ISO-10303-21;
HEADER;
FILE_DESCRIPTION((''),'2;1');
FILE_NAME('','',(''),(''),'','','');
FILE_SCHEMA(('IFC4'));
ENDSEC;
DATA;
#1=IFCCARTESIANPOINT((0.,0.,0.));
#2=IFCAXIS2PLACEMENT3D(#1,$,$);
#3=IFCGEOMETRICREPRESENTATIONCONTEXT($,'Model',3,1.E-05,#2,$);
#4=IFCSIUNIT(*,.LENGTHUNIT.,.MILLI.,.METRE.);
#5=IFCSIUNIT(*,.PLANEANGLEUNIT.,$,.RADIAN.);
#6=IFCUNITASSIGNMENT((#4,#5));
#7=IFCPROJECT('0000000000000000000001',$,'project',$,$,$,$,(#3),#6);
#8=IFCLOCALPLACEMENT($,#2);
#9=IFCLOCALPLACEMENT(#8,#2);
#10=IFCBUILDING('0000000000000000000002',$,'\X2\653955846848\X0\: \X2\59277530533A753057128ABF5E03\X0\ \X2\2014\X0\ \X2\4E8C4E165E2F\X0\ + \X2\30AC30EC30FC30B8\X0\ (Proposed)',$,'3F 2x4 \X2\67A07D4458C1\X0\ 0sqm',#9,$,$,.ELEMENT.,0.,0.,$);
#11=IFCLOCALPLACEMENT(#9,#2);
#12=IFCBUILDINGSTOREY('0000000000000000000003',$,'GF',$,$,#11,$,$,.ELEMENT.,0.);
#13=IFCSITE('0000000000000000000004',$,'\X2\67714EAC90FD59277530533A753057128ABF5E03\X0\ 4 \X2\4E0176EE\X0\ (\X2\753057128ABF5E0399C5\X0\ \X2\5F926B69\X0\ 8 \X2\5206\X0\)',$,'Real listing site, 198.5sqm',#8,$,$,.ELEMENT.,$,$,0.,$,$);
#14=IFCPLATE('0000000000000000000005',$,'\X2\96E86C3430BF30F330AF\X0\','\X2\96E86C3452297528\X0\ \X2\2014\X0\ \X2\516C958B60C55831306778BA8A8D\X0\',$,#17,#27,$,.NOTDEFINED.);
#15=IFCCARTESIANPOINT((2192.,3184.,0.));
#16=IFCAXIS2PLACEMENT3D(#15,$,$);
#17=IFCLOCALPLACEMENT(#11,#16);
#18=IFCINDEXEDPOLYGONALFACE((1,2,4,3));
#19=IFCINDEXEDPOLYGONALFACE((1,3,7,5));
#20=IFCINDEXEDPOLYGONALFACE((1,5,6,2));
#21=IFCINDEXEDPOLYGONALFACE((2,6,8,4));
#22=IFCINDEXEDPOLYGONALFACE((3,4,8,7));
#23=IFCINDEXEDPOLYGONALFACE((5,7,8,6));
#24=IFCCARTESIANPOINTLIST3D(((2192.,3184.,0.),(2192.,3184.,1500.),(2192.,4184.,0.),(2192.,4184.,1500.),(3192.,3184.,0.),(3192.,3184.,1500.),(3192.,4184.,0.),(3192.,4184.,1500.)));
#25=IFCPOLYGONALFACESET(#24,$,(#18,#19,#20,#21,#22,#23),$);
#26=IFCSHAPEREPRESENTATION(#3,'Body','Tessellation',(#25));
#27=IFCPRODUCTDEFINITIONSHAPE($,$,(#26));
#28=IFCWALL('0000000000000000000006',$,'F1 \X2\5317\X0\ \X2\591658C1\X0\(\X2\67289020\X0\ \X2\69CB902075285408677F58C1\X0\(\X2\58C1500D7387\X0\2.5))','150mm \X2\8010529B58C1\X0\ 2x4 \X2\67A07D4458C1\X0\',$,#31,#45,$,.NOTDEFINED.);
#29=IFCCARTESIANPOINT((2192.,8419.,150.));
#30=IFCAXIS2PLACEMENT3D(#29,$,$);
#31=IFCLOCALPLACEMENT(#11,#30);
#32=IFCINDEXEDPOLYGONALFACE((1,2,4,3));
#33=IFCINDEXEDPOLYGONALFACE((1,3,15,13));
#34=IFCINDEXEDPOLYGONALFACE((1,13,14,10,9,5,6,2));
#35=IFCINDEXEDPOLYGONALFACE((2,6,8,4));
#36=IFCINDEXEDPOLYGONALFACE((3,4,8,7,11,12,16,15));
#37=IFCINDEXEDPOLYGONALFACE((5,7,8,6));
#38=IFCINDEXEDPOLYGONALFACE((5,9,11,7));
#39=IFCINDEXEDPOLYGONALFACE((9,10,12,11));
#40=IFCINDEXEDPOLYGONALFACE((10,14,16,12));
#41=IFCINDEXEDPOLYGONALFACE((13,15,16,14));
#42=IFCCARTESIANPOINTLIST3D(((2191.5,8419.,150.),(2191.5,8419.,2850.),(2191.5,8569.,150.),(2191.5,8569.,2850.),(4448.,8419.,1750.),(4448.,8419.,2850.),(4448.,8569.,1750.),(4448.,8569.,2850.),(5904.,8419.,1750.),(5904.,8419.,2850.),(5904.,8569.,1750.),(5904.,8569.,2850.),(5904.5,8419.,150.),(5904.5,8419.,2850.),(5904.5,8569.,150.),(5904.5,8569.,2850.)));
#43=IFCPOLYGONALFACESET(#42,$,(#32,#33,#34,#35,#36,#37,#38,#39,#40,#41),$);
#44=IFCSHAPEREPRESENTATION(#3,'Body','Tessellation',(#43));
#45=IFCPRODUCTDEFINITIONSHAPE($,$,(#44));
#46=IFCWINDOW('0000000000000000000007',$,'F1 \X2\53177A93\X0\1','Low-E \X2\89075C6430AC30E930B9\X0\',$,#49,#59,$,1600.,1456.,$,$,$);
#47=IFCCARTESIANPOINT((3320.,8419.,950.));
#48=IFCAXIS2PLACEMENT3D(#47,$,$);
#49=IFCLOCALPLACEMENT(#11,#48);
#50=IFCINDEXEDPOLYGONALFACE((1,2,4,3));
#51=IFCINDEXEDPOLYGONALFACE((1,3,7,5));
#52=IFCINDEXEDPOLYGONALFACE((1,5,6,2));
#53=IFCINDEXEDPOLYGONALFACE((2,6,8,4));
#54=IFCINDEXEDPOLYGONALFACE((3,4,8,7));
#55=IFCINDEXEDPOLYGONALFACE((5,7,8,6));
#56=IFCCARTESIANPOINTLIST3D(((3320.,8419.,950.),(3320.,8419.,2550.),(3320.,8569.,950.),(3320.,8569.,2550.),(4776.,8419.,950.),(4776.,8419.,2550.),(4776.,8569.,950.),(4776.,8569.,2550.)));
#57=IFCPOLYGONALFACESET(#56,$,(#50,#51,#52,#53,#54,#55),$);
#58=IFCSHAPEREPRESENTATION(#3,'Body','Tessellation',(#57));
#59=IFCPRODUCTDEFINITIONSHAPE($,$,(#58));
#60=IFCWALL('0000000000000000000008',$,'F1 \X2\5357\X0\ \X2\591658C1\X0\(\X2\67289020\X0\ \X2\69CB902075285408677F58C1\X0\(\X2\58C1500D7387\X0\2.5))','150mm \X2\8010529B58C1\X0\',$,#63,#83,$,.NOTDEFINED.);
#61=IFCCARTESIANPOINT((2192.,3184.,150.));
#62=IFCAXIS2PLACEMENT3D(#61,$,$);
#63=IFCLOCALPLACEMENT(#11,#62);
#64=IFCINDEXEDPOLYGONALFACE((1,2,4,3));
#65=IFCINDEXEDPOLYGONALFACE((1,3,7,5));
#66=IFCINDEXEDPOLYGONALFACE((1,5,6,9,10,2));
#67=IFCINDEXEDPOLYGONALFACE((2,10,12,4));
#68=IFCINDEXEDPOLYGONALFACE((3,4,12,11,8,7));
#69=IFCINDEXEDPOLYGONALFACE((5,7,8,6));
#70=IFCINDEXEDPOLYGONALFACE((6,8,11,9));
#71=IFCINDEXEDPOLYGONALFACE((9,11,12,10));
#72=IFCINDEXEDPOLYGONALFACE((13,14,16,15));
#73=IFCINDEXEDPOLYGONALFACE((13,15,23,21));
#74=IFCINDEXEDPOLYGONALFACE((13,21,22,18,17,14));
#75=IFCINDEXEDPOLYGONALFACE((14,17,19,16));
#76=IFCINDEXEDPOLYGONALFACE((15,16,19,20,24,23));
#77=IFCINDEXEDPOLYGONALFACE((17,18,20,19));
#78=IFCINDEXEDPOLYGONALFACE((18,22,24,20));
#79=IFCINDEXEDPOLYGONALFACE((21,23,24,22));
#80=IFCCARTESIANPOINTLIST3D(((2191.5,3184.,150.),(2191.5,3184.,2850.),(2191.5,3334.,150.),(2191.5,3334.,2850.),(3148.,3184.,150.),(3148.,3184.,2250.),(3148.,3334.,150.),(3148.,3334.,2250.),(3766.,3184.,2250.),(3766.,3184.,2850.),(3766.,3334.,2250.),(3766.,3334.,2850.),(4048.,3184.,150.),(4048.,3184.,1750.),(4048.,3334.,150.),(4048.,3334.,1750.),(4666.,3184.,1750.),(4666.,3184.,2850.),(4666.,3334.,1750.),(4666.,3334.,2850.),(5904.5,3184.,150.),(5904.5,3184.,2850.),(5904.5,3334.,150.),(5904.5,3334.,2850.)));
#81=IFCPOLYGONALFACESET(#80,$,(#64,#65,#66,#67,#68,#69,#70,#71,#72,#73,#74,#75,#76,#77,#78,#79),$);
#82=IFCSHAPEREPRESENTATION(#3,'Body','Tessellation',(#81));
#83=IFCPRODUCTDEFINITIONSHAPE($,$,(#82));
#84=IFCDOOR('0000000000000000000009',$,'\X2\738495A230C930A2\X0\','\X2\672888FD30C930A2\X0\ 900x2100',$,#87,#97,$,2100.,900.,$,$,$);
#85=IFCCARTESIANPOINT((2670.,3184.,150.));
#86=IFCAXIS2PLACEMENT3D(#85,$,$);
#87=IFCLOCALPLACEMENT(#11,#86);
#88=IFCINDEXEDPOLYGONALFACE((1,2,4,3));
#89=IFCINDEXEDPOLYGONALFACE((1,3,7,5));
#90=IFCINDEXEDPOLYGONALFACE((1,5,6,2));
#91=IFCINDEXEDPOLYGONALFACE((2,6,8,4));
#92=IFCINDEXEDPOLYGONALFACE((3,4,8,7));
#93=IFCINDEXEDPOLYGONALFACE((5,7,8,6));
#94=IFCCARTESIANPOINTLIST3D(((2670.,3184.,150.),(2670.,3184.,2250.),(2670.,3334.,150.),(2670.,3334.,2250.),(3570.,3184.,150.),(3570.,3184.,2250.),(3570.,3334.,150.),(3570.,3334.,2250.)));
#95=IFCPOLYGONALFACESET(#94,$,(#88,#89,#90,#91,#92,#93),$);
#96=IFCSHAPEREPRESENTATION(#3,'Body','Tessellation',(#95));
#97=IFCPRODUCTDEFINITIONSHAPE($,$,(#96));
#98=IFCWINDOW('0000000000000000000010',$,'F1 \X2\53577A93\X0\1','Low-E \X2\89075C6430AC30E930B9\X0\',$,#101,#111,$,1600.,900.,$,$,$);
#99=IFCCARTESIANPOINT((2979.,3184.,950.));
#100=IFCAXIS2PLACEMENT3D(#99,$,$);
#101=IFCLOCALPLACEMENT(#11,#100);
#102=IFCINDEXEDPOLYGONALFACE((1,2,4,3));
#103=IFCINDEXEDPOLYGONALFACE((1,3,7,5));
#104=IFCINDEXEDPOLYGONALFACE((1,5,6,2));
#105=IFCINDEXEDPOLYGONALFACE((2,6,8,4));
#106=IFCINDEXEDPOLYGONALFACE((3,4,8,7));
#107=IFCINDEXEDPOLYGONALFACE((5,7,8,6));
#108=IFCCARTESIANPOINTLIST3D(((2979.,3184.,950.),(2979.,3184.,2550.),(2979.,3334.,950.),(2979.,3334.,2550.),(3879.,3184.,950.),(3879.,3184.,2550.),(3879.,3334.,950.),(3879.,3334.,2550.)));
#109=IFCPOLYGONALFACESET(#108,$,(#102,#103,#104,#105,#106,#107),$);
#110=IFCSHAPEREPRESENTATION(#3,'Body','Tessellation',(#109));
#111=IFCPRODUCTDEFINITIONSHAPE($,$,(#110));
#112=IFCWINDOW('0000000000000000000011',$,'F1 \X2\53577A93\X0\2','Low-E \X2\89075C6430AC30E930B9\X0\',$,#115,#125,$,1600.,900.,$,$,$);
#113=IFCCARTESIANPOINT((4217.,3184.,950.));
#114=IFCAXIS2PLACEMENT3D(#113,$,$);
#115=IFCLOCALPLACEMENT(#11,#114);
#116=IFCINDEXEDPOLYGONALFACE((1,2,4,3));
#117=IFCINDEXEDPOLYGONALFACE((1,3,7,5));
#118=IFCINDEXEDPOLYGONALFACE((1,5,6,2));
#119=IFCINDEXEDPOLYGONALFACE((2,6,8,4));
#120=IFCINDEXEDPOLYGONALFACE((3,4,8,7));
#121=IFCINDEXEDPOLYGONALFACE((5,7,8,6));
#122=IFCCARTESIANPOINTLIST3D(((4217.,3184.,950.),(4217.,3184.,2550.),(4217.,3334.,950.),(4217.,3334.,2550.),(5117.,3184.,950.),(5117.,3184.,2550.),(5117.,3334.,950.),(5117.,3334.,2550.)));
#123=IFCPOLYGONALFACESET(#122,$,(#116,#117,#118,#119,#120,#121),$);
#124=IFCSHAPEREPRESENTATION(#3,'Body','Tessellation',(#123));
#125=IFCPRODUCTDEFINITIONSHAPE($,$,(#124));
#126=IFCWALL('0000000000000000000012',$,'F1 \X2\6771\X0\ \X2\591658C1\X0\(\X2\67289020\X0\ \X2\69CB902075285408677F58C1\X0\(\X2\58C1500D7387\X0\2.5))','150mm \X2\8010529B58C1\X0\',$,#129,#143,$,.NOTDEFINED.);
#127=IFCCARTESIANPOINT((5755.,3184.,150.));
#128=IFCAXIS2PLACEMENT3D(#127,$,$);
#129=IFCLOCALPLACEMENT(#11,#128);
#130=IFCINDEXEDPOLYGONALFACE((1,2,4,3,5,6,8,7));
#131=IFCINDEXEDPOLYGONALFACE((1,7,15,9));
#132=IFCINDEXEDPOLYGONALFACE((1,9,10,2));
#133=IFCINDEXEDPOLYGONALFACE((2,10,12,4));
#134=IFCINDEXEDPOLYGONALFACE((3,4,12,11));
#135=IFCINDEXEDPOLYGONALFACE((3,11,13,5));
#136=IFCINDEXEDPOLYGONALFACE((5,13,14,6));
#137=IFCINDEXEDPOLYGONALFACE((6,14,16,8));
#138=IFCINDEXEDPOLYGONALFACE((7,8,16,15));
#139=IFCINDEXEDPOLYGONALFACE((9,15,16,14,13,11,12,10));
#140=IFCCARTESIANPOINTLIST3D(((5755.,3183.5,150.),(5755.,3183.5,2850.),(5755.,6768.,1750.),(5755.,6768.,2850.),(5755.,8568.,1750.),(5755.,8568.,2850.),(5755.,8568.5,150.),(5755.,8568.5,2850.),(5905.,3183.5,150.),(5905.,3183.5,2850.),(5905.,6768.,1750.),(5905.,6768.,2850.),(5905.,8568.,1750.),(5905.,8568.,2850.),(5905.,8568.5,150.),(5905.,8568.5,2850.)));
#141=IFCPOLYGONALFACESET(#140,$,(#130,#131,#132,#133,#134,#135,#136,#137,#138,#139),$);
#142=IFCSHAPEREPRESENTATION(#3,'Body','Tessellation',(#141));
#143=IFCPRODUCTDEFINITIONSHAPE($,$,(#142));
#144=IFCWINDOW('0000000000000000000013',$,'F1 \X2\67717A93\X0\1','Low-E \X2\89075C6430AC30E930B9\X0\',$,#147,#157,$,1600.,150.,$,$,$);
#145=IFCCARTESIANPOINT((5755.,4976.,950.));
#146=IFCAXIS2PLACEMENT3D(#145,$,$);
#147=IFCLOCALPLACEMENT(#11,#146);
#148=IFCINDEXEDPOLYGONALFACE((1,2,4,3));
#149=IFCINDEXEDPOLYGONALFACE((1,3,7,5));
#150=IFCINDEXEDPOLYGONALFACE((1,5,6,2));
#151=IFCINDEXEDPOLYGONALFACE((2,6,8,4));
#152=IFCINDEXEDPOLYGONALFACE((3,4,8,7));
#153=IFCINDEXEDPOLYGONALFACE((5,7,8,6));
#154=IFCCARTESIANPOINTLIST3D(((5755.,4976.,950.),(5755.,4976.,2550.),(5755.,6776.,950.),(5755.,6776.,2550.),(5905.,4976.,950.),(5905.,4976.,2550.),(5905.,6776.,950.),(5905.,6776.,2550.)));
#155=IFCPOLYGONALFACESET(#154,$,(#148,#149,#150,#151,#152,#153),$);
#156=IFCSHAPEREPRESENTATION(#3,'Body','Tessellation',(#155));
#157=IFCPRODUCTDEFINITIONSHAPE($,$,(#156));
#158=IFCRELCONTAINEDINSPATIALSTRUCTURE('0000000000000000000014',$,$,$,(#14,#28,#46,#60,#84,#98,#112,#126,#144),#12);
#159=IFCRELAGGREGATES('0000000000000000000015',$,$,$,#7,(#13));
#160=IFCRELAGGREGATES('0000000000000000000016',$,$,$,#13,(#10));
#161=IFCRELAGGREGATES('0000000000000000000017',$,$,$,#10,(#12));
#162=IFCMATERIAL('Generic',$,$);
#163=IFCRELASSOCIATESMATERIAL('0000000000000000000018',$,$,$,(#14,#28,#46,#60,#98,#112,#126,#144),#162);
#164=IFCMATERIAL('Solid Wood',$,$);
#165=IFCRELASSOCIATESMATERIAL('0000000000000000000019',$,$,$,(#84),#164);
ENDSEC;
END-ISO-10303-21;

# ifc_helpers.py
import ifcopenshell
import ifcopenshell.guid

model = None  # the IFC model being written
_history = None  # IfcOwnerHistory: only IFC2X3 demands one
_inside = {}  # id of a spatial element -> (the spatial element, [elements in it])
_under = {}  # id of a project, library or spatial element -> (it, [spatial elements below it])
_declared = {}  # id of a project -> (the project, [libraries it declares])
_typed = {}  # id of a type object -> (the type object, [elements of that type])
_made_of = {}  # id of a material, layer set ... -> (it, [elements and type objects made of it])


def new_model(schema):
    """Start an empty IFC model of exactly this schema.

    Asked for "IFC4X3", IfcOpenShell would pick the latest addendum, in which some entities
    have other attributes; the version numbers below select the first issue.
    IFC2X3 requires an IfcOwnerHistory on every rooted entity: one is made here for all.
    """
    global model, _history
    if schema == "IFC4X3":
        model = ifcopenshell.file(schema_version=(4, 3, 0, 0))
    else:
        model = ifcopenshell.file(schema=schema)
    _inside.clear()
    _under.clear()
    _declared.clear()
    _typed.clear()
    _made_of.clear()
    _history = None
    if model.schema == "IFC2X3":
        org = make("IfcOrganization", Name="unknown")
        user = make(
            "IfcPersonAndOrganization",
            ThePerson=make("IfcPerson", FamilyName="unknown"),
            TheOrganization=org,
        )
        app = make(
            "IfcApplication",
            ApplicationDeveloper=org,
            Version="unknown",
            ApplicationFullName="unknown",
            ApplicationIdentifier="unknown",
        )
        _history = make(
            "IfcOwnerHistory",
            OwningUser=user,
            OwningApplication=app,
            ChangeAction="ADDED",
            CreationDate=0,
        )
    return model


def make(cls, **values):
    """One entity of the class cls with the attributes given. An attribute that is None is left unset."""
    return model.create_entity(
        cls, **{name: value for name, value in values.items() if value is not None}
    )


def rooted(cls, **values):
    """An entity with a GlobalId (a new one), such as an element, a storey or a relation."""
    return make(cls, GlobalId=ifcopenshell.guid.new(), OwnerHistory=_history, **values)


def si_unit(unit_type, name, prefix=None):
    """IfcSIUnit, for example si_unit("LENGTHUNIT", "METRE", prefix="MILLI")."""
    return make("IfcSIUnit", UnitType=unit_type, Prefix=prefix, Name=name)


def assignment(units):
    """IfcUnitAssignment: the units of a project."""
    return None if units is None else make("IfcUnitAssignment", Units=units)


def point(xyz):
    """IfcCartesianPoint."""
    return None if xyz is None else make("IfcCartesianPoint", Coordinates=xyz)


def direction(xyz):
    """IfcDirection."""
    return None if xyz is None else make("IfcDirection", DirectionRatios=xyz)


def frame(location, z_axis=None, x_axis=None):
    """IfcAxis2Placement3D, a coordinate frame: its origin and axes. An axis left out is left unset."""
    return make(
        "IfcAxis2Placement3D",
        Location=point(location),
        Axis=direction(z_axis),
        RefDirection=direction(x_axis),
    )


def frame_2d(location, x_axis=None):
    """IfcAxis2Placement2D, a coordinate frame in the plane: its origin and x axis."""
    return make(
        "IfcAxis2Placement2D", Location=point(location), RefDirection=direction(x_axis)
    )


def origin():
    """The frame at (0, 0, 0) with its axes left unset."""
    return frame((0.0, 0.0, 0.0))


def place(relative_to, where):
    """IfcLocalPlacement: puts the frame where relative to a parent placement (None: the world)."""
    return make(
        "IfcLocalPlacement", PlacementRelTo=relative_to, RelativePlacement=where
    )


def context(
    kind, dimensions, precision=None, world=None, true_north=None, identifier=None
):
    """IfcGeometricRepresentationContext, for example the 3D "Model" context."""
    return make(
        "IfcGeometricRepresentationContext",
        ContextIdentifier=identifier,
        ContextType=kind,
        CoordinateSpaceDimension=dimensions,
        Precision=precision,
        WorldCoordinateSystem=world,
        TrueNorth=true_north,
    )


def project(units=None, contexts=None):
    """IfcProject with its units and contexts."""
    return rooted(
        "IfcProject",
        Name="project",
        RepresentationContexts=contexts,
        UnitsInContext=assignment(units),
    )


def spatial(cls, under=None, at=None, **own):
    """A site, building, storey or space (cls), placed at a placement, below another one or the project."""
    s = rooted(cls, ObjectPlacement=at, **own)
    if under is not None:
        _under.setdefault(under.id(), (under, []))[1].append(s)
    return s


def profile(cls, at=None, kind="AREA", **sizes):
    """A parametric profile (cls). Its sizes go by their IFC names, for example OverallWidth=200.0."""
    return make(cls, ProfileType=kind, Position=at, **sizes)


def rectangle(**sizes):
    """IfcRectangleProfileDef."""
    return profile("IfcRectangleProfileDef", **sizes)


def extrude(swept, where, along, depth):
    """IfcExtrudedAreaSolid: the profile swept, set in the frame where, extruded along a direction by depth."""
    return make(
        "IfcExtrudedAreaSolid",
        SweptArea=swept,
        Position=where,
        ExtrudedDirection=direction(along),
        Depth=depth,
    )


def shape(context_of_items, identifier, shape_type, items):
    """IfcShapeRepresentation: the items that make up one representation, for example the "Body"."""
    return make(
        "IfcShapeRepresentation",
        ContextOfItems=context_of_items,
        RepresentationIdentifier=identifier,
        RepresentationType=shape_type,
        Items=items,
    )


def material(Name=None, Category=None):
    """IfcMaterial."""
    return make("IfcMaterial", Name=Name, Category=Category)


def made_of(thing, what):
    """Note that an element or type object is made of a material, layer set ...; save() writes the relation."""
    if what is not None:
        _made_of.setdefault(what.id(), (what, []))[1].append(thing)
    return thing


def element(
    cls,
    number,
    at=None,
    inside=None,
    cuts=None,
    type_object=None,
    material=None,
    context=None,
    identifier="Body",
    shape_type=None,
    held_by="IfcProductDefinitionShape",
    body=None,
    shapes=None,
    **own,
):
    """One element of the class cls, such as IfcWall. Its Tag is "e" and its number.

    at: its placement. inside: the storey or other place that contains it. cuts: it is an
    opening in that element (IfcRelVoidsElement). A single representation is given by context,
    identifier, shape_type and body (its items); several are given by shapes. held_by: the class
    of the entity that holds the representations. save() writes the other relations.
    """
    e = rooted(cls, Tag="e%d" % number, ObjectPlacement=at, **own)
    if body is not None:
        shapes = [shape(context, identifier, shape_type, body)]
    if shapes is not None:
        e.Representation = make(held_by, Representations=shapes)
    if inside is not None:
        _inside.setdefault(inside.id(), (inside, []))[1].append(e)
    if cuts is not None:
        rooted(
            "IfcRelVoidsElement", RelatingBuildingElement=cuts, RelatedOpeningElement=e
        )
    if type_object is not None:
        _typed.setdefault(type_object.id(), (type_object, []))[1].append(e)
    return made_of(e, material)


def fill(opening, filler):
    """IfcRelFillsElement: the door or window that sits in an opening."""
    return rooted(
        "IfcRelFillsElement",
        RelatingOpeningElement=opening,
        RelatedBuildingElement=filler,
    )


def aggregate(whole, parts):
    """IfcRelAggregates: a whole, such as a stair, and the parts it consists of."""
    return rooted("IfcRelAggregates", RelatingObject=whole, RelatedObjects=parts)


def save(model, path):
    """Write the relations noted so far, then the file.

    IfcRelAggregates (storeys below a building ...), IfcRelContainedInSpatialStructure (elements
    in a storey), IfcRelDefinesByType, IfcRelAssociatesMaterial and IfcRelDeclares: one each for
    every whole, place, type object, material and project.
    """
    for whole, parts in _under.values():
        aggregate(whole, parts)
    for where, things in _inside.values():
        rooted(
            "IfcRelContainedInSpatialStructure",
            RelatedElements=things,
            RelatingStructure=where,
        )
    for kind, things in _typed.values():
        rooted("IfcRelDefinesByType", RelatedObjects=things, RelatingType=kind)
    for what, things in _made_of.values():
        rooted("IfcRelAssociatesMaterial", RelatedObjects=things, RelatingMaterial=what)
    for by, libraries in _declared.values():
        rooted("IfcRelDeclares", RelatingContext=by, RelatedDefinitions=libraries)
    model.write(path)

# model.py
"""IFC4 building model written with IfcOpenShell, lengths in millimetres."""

from ifc_helpers import new_model, si_unit, frame, frame_2d, origin, place, context, project, spatial, rectangle, extrude, material, element, fill, save


model = new_model("IFC4")

# Units and contexts
model_context = context("Model", 3, precision=1e-05, world=origin())
ifc_project = project(units=[si_unit("LENGTHUNIT", "METRE", prefix="MILLI"), si_unit("PLANEANGLEUNIT", "RADIAN")], contexts=[model_context])

# Site, building, storey
site_placement = place(None, origin())
site = spatial("IfcSite", under=ifc_project, at=site_placement, Name="東京都大田区田園調布 4 丁目 (田園調布駅 徒歩 8 分)", ObjectType="Real listing site, 198.5sqm", CompositionType="ELEMENT", RefElevation=0.0)
building_placement = place(site_placement, origin())
building = spatial("IfcBuilding", under=site, at=building_placement, Name="改善案: 大田区田園調布 — 二世帯 + ガレージ (Proposed)", ObjectType="3F 2x4 枠組壁 0sqm", CompositionType="ELEMENT", ElevationOfRefHeight=0.0, ElevationOfTerrain=0.0)
storey_placement = place(building_placement, origin())
storey = spatial("IfcBuildingStorey", under=building, at=storey_placement, Name="GF", CompositionType="ELEMENT", Elevation=0.0)

# Shared definitions
ifc_material_1 = material(Name="Generic")

# Plate
plate_placement = place(storey_placement, frame((2192.0, 3184.0, 0.0)))
element("IfcPlate", 1, at=plate_placement, inside=storey, material=ifc_material_1, Name="雨水タンク", Description="雨水利用 — 公開情報で確認", PredefinedType="NOTDEFINED", context=model_context, shape_type="SweptSolid", body=[
    extrude(rectangle(XDim=1000.0, YDim=1000.0, at=frame_2d((500.0, 500.0))), frame((2192.0, 3184.0, 0.0)), (0.0, 0.0, 1.0), 1500.0),
])

# Wall, opening, window
wall_1_placement = place(storey_placement, frame((2192.0, 8419.0, 150.0)))
wall_1 = element("IfcWall", 2, at=wall_1_placement, inside=storey, material=ifc_material_1, Name="F1 北 外壁(木造 構造用合板壁(壁倍率2.5))", Description="150mm 耐力壁 2x4 枠組壁", PredefinedType="NOTDEFINED", context=model_context, shape_type="SweptSolid", body=[
    extrude(rectangle(XDim=3713.0, YDim=150.0, at=frame_2d((1856.0, 75.0))), frame((2192.0, 8419.0, 150.0)), (0.0, 0.0, 1.0), 2700.0),
])
opening_1_placement = place(storey_placement, frame((3320.0, 8419.0, 950.0)))
opening_1 = element("IfcOpeningElement", 3, at=opening_1_placement, cuts=wall_1, PredefinedType="NOTDEFINED", context=model_context, shape_type="SweptSolid", body=[
    extrude(rectangle(XDim=1456.0, YDim=150.0, at=frame_2d((728.0, 75.0))), frame((3320.0, 8419.0, 950.0)), (0.0, 0.0, 1.0), 1600.0),
])
window_1_placement = place(storey_placement, frame((3320.0, 8419.0, 950.0)))
window_1 = element("IfcWindow", 4, at=window_1_placement, inside=storey, material=ifc_material_1, Name="F1 北窓1", Description="Low-E 複層ガラス", OverallHeight=1600.0, OverallWidth=1456.0, context=model_context, shape_type="SweptSolid", body=[
    extrude(rectangle(XDim=1456.0, YDim=150.0, at=frame_2d((728.0, 75.0))), frame((3320.0, 8419.0, 950.0)), (0.0, 0.0, 1.0), 1600.0),
])
fill(opening_1, window_1)

# Wall, openings, door, windows
wall_2_placement = place(storey_placement, frame((2192.0, 3184.0, 150.0)))
wall_2 = element("IfcWall", 5, at=wall_2_placement, inside=storey, material=ifc_material_1, Name="F1 南 外壁(木造 構造用合板壁(壁倍率2.5))", Description="150mm 耐力壁", PredefinedType="NOTDEFINED", context=model_context, shape_type="SweptSolid", body=[
    extrude(rectangle(XDim=3713.0, YDim=150.0, at=frame_2d((1856.0, 75.0))), frame((2192.0, 3184.0, 150.0)), (0.0, 0.0, 1.0), 2700.0),
])
opening_2_placement = place(storey_placement, frame((2670.0, 3184.0, 150.0)))
opening_2 = element("IfcOpeningElement", 6, at=opening_2_placement, cuts=wall_2, PredefinedType="NOTDEFINED", context=model_context, shape_type="SweptSolid", body=[
    extrude(rectangle(XDim=900.0, YDim=150.0, at=frame_2d((450.0, 75.0))), frame((2670.0, 3184.0, 150.0)), (0.0, 0.0, 1.0), 2100.0),
])
opening_3_placement = place(storey_placement, frame((2979.0, 3184.0, 950.0)))
opening_3 = element("IfcOpeningElement", 7, at=opening_3_placement, cuts=wall_2, PredefinedType="NOTDEFINED", context=model_context, shape_type="SweptSolid", body=[
    extrude(rectangle(XDim=900.0, YDim=150.0, at=frame_2d((450.0, 75.0))), frame((2979.0, 3184.0, 950.0)), (0.0, 0.0, 1.0), 1600.0),
])
opening_4_placement = place(storey_placement, frame((4217.0, 3184.0, 950.0)))
opening_4 = element("IfcOpeningElement", 8, at=opening_4_placement, cuts=wall_2, PredefinedType="NOTDEFINED", context=model_context, shape_type="SweptSolid", body=[
    extrude(rectangle(XDim=900.0, YDim=150.0, at=frame_2d((450.0, 75.0))), frame((4217.0, 3184.0, 950.0)), (0.0, 0.0, 1.0), 1600.0),
])
ifc_material_2 = material(Name="Solid Wood")
door_placement = place(storey_placement, frame((2670.0, 3184.0, 150.0)))
door = element("IfcDoor", 9, at=door_placement, inside=storey, material=ifc_material_2, Name="玄関ドア", Description="木製ドア 900x2100", OverallHeight=2100.0, OverallWidth=900.0, context=model_context, shape_type="SweptSolid", body=[
    extrude(rectangle(XDim=900.0, YDim=150.0, at=frame_2d((450.0, 75.0))), frame((2670.0, 3184.0, 150.0)), (0.0, 0.0, 1.0), 2100.0),
])
fill(opening_2, door)
window_2_placement = place(storey_placement, frame((2979.0, 3184.0, 950.0)))
window_2 = element("IfcWindow", 10, at=window_2_placement, inside=storey, material=ifc_material_1, Name="F1 南窓1", Description="Low-E 複層ガラス", OverallHeight=1600.0, OverallWidth=900.0, context=model_context, shape_type="SweptSolid", body=[
    extrude(rectangle(XDim=900.0, YDim=150.0, at=frame_2d((450.0, 75.0))), frame((2979.0, 3184.0, 950.0)), (0.0, 0.0, 1.0), 1600.0),
])
fill(opening_3, window_2)
window_3_placement = place(storey_placement, frame((4217.0, 3184.0, 950.0)))
window_3 = element("IfcWindow", 11, at=window_3_placement, inside=storey, material=ifc_material_1, Name="F1 南窓2", Description="Low-E 複層ガラス", OverallHeight=1600.0, OverallWidth=900.0, context=model_context, shape_type="SweptSolid", body=[
    extrude(rectangle(XDim=900.0, YDim=150.0, at=frame_2d((450.0, 75.0))), frame((4217.0, 3184.0, 950.0)), (0.0, 0.0, 1.0), 1600.0),
])
fill(opening_4, window_3)

# Wall, opening, window
wall_3_placement = place(storey_placement, frame((5755.0, 3184.0, 150.0)))
wall_3 = element("IfcWall", 12, at=wall_3_placement, inside=storey, material=ifc_material_1, Name="F1 東 外壁(木造 構造用合板壁(壁倍率2.5))", Description="150mm 耐力壁", PredefinedType="NOTDEFINED", context=model_context, shape_type="SweptSolid", body=[
    extrude(rectangle(XDim=150.0, YDim=5385.0, at=frame_2d((75.0, 2692.0))), frame((5755.0, 3184.0, 150.0)), (0.0, 0.0, 1.0), 2700.0),
])
opening_5_placement = place(storey_placement, frame((5755.0, 4976.0, 950.0)))
opening_5 = element("IfcOpeningElement", 13, at=opening_5_placement, cuts=wall_3, PredefinedType="NOTDEFINED", context=model_context, shape_type="SweptSolid", body=[
    extrude(rectangle(XDim=150.0, YDim=1800.0, at=frame_2d((75.0, 900.0))), frame((5755.0, 4976.0, 950.0)), (0.0, 0.0, 1.0), 1600.0),
])
window_4_placement = place(storey_placement, frame((5755.0, 4976.0, 950.0)))
window_4 = element("IfcWindow", 14, at=window_4_placement, inside=storey, material=ifc_material_1, Name="F1 東窓1", Description="Low-E 複層ガラス", OverallHeight=1600.0, OverallWidth=150.0, context=model_context, shape_type="SweptSolid", body=[
    extrude(rectangle(XDim=150.0, YDim=1800.0, at=frame_2d((75.0, 900.0))), frame((5755.0, 4976.0, 950.0)), (0.0, 0.0, 1.0), 1600.0),
])
fill(opening_5, window_4)

save(model, "model.ifc")
